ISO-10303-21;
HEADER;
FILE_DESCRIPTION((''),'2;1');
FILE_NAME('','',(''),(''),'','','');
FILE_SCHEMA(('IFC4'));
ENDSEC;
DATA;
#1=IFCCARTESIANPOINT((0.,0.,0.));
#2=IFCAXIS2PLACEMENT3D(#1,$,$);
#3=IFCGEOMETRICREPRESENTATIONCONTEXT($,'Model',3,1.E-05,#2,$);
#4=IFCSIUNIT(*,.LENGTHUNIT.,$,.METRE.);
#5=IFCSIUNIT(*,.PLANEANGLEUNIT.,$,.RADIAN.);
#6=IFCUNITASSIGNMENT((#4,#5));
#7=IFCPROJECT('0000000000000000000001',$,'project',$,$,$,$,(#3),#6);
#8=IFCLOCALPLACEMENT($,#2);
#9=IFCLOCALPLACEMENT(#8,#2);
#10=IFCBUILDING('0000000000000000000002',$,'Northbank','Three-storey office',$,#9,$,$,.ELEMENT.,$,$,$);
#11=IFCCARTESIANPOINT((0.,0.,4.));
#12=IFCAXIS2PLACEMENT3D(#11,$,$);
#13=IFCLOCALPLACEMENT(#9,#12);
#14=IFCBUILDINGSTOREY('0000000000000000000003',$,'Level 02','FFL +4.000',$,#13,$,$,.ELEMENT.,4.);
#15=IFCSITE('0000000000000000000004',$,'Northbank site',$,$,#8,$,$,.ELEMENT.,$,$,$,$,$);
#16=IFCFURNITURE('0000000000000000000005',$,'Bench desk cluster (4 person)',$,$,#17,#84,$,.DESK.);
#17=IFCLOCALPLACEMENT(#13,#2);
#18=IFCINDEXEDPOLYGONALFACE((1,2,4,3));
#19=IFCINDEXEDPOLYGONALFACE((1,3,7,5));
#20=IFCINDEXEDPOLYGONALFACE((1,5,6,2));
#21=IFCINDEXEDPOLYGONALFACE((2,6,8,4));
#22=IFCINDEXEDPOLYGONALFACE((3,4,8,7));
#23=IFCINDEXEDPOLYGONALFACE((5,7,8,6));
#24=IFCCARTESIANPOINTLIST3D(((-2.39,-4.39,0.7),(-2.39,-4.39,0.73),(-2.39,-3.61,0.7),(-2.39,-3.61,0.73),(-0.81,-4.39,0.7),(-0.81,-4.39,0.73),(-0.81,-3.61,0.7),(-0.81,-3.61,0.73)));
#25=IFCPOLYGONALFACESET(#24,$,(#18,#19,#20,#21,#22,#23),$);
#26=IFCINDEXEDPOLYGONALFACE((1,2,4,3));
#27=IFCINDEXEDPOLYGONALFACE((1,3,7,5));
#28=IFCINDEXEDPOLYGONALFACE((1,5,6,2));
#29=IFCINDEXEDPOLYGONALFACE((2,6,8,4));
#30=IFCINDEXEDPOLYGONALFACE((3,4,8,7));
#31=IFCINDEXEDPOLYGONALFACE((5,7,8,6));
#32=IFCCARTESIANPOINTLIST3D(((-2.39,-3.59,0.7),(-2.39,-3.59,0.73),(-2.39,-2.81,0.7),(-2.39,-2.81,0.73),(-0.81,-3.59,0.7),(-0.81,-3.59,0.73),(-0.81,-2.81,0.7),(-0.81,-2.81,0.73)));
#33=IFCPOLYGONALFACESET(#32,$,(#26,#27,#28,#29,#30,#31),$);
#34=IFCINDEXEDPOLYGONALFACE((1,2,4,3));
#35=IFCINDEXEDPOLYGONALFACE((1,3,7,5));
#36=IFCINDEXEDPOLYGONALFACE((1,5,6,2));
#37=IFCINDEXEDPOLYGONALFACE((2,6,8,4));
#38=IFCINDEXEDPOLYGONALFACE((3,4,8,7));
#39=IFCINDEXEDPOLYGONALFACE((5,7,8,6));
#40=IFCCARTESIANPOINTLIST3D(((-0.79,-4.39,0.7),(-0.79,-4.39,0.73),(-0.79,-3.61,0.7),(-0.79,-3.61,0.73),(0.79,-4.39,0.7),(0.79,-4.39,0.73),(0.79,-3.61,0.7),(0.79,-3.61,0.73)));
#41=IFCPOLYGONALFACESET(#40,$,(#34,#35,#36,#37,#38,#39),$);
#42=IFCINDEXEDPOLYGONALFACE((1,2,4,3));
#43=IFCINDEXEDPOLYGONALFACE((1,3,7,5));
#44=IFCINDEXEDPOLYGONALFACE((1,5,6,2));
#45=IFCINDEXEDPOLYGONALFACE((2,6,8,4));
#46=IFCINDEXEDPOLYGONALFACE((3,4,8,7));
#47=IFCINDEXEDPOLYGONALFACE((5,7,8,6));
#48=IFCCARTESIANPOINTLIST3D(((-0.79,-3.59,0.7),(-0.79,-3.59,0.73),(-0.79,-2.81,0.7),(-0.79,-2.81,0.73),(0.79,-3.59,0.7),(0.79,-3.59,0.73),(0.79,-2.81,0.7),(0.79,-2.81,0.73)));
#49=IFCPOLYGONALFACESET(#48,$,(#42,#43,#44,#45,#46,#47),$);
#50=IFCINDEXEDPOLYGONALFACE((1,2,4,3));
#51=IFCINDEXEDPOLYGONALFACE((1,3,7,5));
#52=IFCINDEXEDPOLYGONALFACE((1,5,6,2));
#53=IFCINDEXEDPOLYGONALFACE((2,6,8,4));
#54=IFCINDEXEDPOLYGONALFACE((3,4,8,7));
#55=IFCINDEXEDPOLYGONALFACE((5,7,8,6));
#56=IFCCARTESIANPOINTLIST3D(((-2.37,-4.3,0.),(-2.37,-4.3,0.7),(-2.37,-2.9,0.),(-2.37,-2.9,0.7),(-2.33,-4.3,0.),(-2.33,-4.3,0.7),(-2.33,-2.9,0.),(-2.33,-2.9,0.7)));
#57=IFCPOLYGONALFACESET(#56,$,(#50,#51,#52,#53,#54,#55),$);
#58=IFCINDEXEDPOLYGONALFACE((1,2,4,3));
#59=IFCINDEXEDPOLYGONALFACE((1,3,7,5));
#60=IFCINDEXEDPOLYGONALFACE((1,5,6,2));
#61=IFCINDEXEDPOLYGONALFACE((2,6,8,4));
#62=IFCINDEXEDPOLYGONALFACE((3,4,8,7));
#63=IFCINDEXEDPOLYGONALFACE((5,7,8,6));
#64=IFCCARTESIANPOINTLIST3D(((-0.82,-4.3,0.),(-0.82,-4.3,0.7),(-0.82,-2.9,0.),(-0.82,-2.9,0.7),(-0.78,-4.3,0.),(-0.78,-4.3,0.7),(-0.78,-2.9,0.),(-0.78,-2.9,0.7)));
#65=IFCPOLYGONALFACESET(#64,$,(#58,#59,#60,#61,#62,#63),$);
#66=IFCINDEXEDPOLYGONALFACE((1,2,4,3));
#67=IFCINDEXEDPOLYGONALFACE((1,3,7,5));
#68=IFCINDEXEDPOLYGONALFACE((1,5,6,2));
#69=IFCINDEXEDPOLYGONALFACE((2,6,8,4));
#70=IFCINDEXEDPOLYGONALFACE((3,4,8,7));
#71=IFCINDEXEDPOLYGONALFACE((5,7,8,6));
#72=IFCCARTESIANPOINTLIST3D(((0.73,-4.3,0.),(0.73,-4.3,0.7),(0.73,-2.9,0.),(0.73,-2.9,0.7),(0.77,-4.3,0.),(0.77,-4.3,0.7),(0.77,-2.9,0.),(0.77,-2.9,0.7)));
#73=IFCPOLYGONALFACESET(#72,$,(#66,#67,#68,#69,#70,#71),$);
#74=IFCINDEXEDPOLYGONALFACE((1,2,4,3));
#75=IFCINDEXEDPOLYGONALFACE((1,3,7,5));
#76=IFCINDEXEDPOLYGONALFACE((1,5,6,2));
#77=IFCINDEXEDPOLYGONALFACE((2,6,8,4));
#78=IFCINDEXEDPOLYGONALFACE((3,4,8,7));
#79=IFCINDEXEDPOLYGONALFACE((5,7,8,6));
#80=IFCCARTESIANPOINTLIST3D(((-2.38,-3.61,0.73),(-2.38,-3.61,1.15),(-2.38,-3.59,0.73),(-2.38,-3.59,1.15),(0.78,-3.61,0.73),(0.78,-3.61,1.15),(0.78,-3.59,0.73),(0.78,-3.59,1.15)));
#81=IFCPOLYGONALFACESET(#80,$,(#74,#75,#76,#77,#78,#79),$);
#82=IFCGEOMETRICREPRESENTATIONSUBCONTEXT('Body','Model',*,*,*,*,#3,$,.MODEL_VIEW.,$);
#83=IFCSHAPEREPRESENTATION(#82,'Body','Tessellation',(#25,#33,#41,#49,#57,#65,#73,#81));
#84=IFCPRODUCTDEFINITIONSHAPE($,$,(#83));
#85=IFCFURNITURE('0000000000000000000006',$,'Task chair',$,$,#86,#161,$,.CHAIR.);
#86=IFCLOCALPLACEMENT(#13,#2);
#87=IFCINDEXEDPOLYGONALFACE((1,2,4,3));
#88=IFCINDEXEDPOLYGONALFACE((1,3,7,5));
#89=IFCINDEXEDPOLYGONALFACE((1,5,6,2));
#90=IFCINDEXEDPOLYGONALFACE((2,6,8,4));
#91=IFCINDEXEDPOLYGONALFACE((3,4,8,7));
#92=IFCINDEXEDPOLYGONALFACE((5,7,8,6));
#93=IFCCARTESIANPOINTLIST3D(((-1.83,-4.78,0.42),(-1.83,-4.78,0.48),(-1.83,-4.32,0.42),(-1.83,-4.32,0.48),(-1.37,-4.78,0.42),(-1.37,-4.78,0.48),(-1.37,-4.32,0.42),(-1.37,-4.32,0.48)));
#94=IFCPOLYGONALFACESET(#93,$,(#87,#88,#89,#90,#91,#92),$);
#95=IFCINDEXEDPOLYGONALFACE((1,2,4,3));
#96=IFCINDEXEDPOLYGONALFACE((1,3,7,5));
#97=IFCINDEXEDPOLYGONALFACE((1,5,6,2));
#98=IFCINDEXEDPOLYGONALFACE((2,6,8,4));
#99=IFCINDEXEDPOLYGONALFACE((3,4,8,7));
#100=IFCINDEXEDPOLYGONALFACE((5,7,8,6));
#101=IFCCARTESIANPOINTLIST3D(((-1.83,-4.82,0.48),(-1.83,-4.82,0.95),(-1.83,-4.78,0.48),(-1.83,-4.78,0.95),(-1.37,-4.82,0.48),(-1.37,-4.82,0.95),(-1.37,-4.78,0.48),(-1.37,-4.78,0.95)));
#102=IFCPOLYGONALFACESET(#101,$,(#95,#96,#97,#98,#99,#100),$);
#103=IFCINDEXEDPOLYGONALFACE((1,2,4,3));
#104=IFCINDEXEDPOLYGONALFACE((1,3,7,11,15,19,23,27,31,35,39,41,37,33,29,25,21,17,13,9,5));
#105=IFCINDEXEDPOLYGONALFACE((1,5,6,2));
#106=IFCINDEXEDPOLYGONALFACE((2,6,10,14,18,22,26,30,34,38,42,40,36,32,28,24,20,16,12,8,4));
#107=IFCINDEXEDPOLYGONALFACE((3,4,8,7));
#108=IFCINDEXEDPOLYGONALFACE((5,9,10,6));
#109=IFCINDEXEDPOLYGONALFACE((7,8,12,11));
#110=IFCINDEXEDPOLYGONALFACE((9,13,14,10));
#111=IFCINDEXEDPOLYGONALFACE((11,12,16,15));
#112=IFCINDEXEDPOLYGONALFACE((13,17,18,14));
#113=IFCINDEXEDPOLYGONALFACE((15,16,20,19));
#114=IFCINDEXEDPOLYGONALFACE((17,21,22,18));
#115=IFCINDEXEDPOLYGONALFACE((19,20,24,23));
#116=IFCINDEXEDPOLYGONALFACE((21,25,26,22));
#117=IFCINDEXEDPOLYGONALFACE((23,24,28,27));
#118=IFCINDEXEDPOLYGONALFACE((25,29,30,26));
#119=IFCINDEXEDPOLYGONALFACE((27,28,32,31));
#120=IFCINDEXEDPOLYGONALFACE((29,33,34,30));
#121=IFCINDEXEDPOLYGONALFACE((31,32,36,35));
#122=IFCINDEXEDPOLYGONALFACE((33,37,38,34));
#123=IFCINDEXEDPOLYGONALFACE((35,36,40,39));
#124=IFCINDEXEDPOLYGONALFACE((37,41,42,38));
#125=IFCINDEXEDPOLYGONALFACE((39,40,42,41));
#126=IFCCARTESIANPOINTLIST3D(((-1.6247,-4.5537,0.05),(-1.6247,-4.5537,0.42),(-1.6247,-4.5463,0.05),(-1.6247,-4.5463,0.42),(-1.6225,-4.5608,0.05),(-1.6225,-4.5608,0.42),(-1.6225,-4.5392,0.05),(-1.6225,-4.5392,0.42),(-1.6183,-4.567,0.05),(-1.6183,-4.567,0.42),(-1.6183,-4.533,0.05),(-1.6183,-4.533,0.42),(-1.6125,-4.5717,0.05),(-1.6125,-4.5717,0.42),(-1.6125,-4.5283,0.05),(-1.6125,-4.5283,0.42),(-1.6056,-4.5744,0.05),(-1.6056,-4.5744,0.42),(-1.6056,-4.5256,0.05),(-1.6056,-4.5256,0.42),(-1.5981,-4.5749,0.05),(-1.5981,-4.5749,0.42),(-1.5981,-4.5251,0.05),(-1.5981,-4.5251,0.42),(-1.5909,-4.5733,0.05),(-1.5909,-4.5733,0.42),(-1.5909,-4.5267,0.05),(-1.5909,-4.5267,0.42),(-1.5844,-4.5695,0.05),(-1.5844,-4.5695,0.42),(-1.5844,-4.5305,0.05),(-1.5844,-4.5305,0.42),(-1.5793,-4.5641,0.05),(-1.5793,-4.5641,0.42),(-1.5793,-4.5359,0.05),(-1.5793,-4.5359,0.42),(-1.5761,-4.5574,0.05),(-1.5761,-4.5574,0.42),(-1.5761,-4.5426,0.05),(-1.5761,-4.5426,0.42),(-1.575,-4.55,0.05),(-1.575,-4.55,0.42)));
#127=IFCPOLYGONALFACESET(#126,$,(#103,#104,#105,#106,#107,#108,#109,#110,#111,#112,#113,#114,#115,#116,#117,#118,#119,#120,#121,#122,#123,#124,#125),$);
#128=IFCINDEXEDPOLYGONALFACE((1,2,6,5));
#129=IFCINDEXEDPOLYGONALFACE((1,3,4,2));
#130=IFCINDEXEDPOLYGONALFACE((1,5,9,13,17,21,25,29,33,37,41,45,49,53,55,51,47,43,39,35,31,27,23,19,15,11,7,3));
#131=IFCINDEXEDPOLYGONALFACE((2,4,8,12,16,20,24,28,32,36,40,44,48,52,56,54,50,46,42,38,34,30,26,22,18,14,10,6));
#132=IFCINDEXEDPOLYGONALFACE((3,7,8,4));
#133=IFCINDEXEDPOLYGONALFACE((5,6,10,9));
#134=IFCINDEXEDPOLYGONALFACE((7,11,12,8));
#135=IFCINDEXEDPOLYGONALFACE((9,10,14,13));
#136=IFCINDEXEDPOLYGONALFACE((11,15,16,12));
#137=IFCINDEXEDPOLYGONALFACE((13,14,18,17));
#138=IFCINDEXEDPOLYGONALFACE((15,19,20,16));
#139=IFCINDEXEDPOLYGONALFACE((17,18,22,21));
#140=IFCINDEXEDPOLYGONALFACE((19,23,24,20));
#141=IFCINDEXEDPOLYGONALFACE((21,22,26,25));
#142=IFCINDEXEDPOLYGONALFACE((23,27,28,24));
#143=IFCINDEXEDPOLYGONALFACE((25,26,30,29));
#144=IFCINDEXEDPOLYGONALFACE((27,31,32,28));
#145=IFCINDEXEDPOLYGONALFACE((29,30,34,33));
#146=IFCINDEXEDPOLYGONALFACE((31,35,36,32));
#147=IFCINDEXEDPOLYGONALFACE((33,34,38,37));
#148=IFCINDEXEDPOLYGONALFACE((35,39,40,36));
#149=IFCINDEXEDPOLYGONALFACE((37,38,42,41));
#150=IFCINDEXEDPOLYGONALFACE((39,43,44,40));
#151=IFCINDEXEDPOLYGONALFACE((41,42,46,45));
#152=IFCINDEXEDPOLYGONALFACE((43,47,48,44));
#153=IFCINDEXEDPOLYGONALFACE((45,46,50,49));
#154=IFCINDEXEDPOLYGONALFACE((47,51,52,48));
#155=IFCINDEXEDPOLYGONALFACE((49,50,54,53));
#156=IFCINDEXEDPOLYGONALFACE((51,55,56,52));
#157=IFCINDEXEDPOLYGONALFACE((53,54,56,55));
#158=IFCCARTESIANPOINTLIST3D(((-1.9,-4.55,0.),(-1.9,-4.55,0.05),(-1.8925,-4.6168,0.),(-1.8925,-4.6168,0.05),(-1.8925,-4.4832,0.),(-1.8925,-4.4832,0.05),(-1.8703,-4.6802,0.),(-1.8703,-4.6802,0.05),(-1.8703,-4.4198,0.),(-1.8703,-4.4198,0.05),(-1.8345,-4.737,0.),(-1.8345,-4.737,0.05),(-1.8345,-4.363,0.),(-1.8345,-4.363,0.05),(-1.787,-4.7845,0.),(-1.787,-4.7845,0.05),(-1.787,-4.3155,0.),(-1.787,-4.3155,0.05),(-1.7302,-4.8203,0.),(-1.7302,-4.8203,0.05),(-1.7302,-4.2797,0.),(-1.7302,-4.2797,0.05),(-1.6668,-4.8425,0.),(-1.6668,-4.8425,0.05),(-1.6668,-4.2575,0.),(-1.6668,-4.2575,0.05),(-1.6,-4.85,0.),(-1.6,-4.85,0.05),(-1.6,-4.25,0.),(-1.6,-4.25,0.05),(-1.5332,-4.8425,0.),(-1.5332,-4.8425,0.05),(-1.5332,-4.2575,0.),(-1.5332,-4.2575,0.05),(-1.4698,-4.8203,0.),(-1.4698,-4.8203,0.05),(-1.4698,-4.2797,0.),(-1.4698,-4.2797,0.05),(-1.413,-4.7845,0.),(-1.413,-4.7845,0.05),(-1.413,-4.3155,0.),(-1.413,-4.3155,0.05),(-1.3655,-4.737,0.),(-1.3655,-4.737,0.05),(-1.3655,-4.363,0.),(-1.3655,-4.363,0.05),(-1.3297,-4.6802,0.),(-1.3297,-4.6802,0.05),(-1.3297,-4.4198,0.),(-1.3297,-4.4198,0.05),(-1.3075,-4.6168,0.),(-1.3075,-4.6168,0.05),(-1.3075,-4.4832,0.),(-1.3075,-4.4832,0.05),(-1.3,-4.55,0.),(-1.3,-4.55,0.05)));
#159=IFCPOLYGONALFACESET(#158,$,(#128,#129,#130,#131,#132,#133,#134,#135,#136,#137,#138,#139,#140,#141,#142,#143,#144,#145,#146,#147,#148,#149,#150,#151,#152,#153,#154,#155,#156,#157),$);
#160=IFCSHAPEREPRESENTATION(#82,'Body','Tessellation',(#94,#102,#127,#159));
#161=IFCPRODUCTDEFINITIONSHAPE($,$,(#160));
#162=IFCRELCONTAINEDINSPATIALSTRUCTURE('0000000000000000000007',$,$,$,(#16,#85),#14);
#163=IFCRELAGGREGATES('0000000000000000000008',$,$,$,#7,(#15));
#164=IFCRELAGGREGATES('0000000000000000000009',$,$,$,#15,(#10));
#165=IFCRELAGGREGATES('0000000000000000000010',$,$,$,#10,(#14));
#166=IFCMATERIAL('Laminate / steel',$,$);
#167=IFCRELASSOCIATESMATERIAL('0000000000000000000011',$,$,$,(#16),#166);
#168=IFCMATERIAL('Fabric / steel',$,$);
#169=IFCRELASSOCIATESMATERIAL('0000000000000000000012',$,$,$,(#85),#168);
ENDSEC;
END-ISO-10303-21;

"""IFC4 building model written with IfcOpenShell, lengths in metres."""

from ifc_helpers import new_model, si_unit, frame, origin, place, context, subcontext, project, spatial, rectangle, circle, extrude, material, element, save


model = new_model("IFC4")

# Units and contexts
model_context = context("Model", 3, precision=1e-05, world=origin())
body_context = subcontext(model_context, "Body", "Model", "MODEL_VIEW")
ifc_project = project(units=[si_unit("LENGTHUNIT", "METRE"), si_unit("PLANEANGLEUNIT", "RADIAN")], contexts=[model_context])

# Site, building, storey
site_placement = place(None, origin())
site = spatial("IfcSite", under=ifc_project, at=site_placement, Name="Northbank site", CompositionType="ELEMENT")
building_placement = place(site_placement, origin())
building = spatial("IfcBuilding", under=site, at=building_placement, Name="Northbank", Description="Three-storey office", CompositionType="ELEMENT")
storey_placement = place(building_placement, frame((0.0, 0.0, 4.0)))
storey = spatial("IfcBuildingStorey", under=building, at=storey_placement, Name="Level 02", Description="FFL +4.000", CompositionType="ELEMENT", Elevation=4.0)

# Furniture
ifc_material_1 = material(Name="Fabric / steel")
ifc_material_2 = material(Name="Laminate / steel")
furniture_1_placement = place(storey_placement, frame((0.0, 0.0, -4.0)))
element("IfcFurniture", 1, at=furniture_1_placement, inside=storey, material=ifc_material_2, Name="Bench desk cluster (4 person)", PredefinedType="DESK", context=body_context, shape_type="SweptSolid", body=[
    extrude(rectangle(XDim=1.58, YDim=0.78), frame((-1.6, -4.0, 4.7)), (0.0, 0.0, 1.0), 0.03),
    extrude(rectangle(XDim=1.58, YDim=0.78), frame((-1.6, -3.2, 4.7)), (0.0, 0.0, 1.0), 0.03),
    extrude(rectangle(XDim=1.58, YDim=0.78), frame((0.0, -4.0, 4.7)), (0.0, 0.0, 1.0), 0.03),
    extrude(rectangle(XDim=1.58, YDim=0.78), frame((0.0, -3.2, 4.7)), (0.0, 0.0, 1.0), 0.03),
    extrude(rectangle(XDim=0.04, YDim=1.4), frame((-2.35, -3.6, 4.0)), (0.0, 0.0, 1.0), 0.7),
    extrude(rectangle(XDim=0.04, YDim=1.4), frame((-0.8, -3.6, 4.0)), (0.0, 0.0, 1.0), 0.7),
    extrude(rectangle(XDim=0.04, YDim=1.4), frame((0.75, -3.6, 4.0)), (0.0, 0.0, 1.0), 0.7),
    extrude(rectangle(XDim=3.16, YDim=0.02), frame((-0.8, -3.6, 4.73)), (0.0, 0.0, 1.0), 0.42),
])
furniture_2_placement = place(storey_placement, frame((0.0, 0.0, -4.0)))
element("IfcFurniture", 2, at=furniture_2_placement, inside=storey, material=ifc_material_1, Name="Task chair", PredefinedType="CHAIR", context=body_context, shape_type="SweptSolid", body=[
    extrude(rectangle(XDim=0.46, YDim=0.46), frame((-1.6, -4.55, 4.42)), (0.0, 0.0, 1.0), 0.06),
    extrude(rectangle(XDim=0.46, YDim=0.04), frame((-1.6, -4.8, 4.48)), (0.0, 0.0, 1.0), 0.47),
    extrude(circle(Radius=0.025), frame((-1.6, -4.55, 4.05), z_axis=(0.0, 0.0, 1.0), x_axis=(1.0, 0.0, 0.0)), (0.0, 0.0, 1.0), 0.37),
    extrude(circle(Radius=0.3), frame((-1.6, -4.55, 4.0), z_axis=(0.0, 0.0, 1.0), x_axis=(1.0, 0.0, 0.0)), (0.0, 0.0, 1.0), 0.05),
])

save(model, "model.ifc")
